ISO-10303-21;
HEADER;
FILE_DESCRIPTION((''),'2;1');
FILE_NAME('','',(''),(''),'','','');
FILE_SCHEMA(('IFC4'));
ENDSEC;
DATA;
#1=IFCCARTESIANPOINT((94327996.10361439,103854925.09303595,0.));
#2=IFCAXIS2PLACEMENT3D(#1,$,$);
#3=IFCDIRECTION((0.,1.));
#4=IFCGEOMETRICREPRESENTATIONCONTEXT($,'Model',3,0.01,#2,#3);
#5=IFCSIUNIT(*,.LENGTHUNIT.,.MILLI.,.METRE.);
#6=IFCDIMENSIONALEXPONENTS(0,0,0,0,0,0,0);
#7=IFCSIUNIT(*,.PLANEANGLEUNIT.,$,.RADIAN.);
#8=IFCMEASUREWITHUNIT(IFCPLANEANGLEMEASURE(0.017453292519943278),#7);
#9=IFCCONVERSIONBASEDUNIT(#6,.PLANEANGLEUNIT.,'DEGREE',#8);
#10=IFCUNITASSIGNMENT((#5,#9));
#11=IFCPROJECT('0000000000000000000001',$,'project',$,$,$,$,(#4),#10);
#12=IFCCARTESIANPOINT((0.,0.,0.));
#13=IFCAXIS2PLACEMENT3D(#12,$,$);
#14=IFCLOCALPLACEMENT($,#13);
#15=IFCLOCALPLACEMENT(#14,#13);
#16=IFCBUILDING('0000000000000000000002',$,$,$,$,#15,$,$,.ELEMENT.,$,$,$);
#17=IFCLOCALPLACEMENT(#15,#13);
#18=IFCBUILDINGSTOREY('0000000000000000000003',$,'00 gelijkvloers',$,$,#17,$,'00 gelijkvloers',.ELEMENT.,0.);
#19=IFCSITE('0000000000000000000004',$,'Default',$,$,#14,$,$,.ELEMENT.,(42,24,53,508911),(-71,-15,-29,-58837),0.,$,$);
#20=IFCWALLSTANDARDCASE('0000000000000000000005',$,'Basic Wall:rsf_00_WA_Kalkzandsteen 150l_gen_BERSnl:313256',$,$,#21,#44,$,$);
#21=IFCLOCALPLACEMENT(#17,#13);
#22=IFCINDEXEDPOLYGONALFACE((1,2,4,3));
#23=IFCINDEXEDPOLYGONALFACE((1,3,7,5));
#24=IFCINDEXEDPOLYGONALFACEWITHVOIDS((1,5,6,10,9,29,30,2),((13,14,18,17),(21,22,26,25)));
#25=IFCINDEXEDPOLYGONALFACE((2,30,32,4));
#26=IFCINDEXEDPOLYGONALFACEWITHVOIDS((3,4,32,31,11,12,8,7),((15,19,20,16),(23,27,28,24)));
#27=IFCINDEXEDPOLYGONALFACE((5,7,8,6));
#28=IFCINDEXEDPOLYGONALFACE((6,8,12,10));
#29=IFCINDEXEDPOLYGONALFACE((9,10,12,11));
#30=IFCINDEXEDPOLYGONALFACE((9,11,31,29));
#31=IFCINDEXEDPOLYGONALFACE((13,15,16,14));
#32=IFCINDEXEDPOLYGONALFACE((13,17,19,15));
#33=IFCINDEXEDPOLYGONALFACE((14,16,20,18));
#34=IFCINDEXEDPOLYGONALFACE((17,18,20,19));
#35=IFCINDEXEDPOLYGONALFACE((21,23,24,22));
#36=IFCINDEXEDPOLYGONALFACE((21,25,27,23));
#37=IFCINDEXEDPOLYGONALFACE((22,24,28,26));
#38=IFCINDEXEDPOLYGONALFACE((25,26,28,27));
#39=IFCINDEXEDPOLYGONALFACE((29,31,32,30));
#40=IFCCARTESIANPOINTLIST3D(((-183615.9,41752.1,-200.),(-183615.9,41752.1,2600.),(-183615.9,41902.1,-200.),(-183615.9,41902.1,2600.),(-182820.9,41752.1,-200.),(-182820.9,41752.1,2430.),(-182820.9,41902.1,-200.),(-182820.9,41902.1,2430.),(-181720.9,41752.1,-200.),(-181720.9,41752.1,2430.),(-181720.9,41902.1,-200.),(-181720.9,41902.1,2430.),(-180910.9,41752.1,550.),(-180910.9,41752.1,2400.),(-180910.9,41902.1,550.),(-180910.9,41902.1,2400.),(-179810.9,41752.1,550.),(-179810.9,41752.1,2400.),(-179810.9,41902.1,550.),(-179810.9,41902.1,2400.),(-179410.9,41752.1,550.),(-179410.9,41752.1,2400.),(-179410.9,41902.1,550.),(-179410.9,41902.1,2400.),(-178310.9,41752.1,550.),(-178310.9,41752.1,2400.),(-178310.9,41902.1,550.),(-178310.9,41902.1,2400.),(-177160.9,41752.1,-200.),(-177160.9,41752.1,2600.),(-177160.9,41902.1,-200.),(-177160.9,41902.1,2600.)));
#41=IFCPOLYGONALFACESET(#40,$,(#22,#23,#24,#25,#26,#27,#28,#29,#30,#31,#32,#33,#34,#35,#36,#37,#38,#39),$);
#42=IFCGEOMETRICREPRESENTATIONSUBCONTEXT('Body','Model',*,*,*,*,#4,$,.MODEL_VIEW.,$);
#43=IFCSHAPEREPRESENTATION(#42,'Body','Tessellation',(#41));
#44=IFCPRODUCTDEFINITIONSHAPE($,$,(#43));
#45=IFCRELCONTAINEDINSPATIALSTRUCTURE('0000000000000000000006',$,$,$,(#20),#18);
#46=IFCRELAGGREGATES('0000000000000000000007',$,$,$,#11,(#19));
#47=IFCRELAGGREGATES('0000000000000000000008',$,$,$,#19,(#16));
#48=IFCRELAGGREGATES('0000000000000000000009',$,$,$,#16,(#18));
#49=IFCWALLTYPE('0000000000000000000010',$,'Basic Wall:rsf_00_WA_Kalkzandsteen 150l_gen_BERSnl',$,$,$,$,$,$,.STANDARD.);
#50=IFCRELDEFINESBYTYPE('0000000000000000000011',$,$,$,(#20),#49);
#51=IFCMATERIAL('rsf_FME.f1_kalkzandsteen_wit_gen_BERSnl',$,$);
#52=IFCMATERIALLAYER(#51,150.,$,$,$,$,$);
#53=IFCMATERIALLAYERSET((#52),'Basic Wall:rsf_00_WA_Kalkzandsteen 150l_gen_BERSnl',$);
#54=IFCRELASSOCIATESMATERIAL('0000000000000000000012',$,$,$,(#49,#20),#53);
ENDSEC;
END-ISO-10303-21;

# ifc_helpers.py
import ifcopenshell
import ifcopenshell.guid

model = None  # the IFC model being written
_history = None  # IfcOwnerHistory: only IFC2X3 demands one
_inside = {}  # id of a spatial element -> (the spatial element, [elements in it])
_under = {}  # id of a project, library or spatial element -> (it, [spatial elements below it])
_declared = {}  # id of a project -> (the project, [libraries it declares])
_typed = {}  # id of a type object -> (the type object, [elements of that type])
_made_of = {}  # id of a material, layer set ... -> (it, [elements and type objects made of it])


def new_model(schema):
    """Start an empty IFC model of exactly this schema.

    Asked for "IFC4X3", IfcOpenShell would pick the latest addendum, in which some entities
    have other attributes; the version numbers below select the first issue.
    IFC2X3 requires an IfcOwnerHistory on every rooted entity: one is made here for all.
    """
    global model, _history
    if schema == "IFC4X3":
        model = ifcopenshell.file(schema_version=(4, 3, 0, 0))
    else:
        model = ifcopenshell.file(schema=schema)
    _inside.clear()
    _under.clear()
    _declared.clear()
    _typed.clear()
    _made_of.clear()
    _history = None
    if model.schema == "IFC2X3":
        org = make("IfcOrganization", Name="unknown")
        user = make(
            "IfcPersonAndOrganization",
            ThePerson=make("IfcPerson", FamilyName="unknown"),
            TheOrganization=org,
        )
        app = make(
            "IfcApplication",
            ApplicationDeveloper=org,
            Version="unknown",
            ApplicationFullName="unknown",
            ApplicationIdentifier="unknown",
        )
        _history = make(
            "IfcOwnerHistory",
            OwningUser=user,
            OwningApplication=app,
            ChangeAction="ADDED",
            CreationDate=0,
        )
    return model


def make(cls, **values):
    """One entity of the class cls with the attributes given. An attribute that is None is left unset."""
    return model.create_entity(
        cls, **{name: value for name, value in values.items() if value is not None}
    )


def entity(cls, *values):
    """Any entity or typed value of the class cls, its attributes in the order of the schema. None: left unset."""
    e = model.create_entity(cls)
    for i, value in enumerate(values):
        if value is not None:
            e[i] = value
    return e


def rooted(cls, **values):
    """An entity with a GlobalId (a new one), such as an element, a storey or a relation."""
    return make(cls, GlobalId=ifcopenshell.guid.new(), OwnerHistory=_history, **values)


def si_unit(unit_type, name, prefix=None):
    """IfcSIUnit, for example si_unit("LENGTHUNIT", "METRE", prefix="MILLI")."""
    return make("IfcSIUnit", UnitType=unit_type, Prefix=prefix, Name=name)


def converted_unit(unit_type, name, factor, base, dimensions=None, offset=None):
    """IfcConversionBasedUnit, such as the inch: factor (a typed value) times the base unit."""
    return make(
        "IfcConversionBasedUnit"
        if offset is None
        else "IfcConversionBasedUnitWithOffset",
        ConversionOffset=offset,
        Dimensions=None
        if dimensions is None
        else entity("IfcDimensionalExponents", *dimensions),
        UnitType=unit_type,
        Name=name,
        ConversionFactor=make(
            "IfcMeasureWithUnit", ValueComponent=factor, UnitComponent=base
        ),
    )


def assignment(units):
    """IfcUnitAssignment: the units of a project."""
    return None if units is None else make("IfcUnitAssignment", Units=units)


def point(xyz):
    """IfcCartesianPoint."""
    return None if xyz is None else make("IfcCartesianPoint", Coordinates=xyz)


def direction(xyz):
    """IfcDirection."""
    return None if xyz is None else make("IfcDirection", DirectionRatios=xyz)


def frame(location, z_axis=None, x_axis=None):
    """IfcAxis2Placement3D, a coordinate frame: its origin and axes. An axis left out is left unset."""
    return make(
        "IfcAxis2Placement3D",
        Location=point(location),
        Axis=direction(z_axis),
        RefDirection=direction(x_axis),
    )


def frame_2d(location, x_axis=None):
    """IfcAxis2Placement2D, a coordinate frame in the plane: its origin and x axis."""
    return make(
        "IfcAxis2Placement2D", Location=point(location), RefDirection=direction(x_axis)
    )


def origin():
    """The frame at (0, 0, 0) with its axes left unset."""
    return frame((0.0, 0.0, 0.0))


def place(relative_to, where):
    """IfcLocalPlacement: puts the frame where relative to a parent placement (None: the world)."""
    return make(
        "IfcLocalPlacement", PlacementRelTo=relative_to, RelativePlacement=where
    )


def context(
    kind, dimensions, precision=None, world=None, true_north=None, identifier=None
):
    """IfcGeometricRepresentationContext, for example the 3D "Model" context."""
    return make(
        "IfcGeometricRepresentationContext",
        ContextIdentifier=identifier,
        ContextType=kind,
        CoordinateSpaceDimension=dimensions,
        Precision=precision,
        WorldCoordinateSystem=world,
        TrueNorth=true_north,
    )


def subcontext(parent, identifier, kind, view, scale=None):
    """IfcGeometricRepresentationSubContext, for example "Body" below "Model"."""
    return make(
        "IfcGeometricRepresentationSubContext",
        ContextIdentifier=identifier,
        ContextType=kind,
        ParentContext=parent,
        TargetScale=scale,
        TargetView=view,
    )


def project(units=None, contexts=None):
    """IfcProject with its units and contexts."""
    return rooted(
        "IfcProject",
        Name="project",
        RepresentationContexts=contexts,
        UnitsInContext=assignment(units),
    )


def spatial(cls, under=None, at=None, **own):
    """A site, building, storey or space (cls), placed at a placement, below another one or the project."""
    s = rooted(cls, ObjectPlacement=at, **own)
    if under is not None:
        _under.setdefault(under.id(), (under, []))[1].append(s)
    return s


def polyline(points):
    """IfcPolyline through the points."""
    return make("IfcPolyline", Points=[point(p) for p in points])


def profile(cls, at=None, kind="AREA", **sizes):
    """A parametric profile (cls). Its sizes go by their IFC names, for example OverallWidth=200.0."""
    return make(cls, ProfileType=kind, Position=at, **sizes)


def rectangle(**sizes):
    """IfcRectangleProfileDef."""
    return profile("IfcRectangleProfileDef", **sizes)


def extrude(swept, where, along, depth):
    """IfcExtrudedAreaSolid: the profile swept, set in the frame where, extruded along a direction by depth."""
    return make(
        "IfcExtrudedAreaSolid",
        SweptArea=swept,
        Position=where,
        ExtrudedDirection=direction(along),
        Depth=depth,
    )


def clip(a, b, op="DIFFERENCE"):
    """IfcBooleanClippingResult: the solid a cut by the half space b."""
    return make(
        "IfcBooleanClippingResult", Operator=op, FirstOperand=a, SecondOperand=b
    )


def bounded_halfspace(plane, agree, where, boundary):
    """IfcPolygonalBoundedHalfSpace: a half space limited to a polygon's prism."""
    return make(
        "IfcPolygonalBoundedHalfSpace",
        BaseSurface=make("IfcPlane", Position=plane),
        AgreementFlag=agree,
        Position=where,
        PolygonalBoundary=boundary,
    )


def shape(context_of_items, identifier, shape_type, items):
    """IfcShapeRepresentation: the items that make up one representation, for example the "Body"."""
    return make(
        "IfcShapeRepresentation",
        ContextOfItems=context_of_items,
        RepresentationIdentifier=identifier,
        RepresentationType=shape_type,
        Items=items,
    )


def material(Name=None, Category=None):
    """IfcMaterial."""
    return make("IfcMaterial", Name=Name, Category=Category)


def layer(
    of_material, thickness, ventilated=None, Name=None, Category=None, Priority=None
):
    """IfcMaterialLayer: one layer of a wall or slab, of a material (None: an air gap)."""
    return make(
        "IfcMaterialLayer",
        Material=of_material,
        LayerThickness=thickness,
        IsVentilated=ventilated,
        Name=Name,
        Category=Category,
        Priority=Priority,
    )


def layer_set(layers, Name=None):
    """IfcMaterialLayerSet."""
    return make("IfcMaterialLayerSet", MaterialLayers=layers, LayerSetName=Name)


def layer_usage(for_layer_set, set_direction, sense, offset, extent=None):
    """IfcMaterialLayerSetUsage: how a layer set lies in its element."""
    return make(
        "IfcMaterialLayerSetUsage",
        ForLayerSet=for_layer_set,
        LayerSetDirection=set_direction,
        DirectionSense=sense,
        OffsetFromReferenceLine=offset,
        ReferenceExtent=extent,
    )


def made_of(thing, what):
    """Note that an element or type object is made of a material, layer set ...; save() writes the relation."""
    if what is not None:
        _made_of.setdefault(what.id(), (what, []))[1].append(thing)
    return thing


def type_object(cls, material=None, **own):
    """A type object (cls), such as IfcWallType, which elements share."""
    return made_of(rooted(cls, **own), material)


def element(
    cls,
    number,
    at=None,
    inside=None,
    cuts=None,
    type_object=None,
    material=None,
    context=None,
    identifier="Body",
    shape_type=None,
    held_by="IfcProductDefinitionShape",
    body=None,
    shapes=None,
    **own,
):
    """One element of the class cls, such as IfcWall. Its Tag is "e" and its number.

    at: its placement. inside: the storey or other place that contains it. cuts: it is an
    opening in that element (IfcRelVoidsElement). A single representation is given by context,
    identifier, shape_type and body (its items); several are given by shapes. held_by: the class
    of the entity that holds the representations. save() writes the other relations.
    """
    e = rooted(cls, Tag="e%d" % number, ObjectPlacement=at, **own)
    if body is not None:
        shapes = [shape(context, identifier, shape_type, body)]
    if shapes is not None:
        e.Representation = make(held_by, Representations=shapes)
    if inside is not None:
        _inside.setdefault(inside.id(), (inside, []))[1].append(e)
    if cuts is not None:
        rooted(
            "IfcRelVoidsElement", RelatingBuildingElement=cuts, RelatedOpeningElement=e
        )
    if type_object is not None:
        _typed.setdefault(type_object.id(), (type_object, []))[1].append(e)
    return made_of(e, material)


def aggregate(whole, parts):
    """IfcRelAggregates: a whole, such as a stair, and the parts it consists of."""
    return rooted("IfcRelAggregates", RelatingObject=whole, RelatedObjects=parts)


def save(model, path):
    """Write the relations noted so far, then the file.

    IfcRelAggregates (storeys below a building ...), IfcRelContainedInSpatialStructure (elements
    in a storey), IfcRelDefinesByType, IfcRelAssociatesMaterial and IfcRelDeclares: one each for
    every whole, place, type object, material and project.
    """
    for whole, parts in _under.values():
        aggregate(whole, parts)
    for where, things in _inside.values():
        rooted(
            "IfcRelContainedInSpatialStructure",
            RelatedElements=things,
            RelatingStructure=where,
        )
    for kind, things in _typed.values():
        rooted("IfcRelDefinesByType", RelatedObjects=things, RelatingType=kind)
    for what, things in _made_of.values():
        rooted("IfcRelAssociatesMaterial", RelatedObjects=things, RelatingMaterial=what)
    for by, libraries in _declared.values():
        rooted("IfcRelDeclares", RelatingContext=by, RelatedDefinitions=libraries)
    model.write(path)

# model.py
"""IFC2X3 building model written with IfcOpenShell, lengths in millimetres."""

from ifc_helpers import new_model, entity, si_unit, converted_unit, direction, frame, frame_2d, origin, place, context, subcontext, project, spatial, polyline, rectangle, extrude, clip, bounded_halfspace, material, layer, layer_set, layer_usage, type_object, element, save


model = new_model("IFC2X3")

# Units and contexts
model_context = context("Model", 3, precision=0.01, world=frame((94327996.10361439, 103854925.09303595, 0.0)), true_north=direction((0.0, 1.0)))
body_context = subcontext(model_context, "Body", "Model", "MODEL_VIEW")
ifc_project = project(units=[si_unit("LENGTHUNIT", "METRE", prefix="MILLI"), converted_unit("PLANEANGLEUNIT", "DEGREE", entity("IfcPlaneAngleMeasure", 0.017453292519943278), si_unit("PLANEANGLEUNIT", "RADIAN"), dimensions=[0, 0, 0, 0, 0, 0, 0])], contexts=[model_context])

# Site, building, storey
site_placement = place(None, origin())
site = spatial("IfcSite", under=ifc_project, at=site_placement, Name="Default", CompositionType="ELEMENT", RefLatitude=(42, 24, 53, 508911), RefLongitude=(-71, -15, -29, -58837), RefElevation=0.0)
building_placement = place(site_placement, origin())
building = spatial("IfcBuilding", under=site, at=building_placement, CompositionType="ELEMENT")
storey_placement = place(building_placement, origin())
storey = spatial("IfcBuildingStorey", under=building, at=storey_placement, Name="00 gelijkvloers", LongName="00 gelijkvloers", CompositionType="ELEMENT", Elevation=0.0)

# Shared definitions
ifc_material_1 = material(Name="rsf_FME.f1_kalkzandsteen_wit_gen_BERSnl")
ifc_layer_1 = layer(ifc_material_1, 150.0)
ifc_layer_set_1 = layer_set([ifc_layer_1], Name="Basic Wall:rsf_00_WA_Kalkzandsteen 150l_gen_BERSnl")
wall_type_1 = type_object("IfcWallType", Name="Basic Wall:rsf_00_WA_Kalkzandsteen 150l_gen_BERSnl", PredefinedType="STANDARD", material=ifc_layer_set_1)

# Wall, openings
ifc_layer_usage_1 = layer_usage(ifc_layer_set_1, "AXIS2", "NEGATIVE", 75.0)
wall_1_placement = place(storey_placement, frame((-183615.9, 41827.1, -200.0)))
wall_1 = element("IfcWallStandardCase", 1, at=wall_1_placement, inside=storey, type_object=wall_type_1, material=ifc_layer_usage_1, Name="Basic Wall:rsf_00_WA_Kalkzandsteen 150l_gen_BERSnl:313256", context=body_context, shape_type="Clipping", body=[
    clip(extrude(rectangle(XDim=6455.0, YDim=150.0, at=frame_2d((3227.5, 0.0), x_axis=(-1.0, 0.0))), origin(), (0.0, 0.0, 1.0), 2800.0), bounded_halfspace(frame((0.0, -75.0, 2800.0), z_axis=(0.0, 0.0, -1.0), x_axis=(1.0, 0.0, 0.0)), True, frame((0.0, -75.0, 2800.0)), polyline([(0.0, 0.0), (6455.0, 0.0), (6455.0, 150.0), (6305.0, 150.0), (2295.0, 150.0), (2145.0, 150.0), (150.0, 150.0), (0.0, 150.0), (0.0, 0.0)]))),
])
opening_1_placement = place(wall_1_placement, frame((183615.9, -41827.1, 200.0)))
element("IfcOpeningElement", 2, at=opening_1_placement, cuts=wall_1, ObjectType="Opening", context=body_context, shape_type="SweptSolid", body=[
    extrude(rectangle(XDim=2630.0, YDim=1100.0, at=frame_2d((0.0, 0.0), x_axis=(1.0, 0.0))), frame((-182270.9, 40378.1, 1115.0), z_axis=(0.0, 1.0, 0.0), x_axis=(0.0, 0.0, 1.0)), (0.0, 0.0, 1.0), 3048.0),
])
opening_2_placement = place(wall_1_placement, frame((183615.9, -41827.1, 200.0)))
element("IfcOpeningElement", 3, at=opening_2_placement, cuts=wall_1, ObjectType="Opening", context=body_context, shape_type="SweptSolid", body=[
    extrude(rectangle(XDim=1850.0, YDim=1100.0, at=frame_2d((0.0, 0.0), x_axis=(0.0, 1.0))), frame((-180360.9, 40228.1, 1475.0), z_axis=(0.0, 1.0, 0.0), x_axis=(-1.0, 0.0, 0.0)), (0.0, 0.0, 1.0), 3048.0),
])
opening_3_placement = place(wall_1_placement, frame((183615.9, -41827.1, 200.0)))
element("IfcOpeningElement", 4, at=opening_3_placement, cuts=wall_1, ObjectType="Opening", context=body_context, shape_type="SweptSolid", body=[
    extrude(rectangle(XDim=1850.0, YDim=1100.0, at=frame_2d((0.0, 0.0), x_axis=(0.0, 1.0))), frame((-178860.9, 40228.1, 1475.0), z_axis=(0.0, 1.0, 0.0), x_axis=(-1.0, 0.0, 0.0)), (0.0, 0.0, 1.0), 3048.0),
])

save(model, "model.ifc")
